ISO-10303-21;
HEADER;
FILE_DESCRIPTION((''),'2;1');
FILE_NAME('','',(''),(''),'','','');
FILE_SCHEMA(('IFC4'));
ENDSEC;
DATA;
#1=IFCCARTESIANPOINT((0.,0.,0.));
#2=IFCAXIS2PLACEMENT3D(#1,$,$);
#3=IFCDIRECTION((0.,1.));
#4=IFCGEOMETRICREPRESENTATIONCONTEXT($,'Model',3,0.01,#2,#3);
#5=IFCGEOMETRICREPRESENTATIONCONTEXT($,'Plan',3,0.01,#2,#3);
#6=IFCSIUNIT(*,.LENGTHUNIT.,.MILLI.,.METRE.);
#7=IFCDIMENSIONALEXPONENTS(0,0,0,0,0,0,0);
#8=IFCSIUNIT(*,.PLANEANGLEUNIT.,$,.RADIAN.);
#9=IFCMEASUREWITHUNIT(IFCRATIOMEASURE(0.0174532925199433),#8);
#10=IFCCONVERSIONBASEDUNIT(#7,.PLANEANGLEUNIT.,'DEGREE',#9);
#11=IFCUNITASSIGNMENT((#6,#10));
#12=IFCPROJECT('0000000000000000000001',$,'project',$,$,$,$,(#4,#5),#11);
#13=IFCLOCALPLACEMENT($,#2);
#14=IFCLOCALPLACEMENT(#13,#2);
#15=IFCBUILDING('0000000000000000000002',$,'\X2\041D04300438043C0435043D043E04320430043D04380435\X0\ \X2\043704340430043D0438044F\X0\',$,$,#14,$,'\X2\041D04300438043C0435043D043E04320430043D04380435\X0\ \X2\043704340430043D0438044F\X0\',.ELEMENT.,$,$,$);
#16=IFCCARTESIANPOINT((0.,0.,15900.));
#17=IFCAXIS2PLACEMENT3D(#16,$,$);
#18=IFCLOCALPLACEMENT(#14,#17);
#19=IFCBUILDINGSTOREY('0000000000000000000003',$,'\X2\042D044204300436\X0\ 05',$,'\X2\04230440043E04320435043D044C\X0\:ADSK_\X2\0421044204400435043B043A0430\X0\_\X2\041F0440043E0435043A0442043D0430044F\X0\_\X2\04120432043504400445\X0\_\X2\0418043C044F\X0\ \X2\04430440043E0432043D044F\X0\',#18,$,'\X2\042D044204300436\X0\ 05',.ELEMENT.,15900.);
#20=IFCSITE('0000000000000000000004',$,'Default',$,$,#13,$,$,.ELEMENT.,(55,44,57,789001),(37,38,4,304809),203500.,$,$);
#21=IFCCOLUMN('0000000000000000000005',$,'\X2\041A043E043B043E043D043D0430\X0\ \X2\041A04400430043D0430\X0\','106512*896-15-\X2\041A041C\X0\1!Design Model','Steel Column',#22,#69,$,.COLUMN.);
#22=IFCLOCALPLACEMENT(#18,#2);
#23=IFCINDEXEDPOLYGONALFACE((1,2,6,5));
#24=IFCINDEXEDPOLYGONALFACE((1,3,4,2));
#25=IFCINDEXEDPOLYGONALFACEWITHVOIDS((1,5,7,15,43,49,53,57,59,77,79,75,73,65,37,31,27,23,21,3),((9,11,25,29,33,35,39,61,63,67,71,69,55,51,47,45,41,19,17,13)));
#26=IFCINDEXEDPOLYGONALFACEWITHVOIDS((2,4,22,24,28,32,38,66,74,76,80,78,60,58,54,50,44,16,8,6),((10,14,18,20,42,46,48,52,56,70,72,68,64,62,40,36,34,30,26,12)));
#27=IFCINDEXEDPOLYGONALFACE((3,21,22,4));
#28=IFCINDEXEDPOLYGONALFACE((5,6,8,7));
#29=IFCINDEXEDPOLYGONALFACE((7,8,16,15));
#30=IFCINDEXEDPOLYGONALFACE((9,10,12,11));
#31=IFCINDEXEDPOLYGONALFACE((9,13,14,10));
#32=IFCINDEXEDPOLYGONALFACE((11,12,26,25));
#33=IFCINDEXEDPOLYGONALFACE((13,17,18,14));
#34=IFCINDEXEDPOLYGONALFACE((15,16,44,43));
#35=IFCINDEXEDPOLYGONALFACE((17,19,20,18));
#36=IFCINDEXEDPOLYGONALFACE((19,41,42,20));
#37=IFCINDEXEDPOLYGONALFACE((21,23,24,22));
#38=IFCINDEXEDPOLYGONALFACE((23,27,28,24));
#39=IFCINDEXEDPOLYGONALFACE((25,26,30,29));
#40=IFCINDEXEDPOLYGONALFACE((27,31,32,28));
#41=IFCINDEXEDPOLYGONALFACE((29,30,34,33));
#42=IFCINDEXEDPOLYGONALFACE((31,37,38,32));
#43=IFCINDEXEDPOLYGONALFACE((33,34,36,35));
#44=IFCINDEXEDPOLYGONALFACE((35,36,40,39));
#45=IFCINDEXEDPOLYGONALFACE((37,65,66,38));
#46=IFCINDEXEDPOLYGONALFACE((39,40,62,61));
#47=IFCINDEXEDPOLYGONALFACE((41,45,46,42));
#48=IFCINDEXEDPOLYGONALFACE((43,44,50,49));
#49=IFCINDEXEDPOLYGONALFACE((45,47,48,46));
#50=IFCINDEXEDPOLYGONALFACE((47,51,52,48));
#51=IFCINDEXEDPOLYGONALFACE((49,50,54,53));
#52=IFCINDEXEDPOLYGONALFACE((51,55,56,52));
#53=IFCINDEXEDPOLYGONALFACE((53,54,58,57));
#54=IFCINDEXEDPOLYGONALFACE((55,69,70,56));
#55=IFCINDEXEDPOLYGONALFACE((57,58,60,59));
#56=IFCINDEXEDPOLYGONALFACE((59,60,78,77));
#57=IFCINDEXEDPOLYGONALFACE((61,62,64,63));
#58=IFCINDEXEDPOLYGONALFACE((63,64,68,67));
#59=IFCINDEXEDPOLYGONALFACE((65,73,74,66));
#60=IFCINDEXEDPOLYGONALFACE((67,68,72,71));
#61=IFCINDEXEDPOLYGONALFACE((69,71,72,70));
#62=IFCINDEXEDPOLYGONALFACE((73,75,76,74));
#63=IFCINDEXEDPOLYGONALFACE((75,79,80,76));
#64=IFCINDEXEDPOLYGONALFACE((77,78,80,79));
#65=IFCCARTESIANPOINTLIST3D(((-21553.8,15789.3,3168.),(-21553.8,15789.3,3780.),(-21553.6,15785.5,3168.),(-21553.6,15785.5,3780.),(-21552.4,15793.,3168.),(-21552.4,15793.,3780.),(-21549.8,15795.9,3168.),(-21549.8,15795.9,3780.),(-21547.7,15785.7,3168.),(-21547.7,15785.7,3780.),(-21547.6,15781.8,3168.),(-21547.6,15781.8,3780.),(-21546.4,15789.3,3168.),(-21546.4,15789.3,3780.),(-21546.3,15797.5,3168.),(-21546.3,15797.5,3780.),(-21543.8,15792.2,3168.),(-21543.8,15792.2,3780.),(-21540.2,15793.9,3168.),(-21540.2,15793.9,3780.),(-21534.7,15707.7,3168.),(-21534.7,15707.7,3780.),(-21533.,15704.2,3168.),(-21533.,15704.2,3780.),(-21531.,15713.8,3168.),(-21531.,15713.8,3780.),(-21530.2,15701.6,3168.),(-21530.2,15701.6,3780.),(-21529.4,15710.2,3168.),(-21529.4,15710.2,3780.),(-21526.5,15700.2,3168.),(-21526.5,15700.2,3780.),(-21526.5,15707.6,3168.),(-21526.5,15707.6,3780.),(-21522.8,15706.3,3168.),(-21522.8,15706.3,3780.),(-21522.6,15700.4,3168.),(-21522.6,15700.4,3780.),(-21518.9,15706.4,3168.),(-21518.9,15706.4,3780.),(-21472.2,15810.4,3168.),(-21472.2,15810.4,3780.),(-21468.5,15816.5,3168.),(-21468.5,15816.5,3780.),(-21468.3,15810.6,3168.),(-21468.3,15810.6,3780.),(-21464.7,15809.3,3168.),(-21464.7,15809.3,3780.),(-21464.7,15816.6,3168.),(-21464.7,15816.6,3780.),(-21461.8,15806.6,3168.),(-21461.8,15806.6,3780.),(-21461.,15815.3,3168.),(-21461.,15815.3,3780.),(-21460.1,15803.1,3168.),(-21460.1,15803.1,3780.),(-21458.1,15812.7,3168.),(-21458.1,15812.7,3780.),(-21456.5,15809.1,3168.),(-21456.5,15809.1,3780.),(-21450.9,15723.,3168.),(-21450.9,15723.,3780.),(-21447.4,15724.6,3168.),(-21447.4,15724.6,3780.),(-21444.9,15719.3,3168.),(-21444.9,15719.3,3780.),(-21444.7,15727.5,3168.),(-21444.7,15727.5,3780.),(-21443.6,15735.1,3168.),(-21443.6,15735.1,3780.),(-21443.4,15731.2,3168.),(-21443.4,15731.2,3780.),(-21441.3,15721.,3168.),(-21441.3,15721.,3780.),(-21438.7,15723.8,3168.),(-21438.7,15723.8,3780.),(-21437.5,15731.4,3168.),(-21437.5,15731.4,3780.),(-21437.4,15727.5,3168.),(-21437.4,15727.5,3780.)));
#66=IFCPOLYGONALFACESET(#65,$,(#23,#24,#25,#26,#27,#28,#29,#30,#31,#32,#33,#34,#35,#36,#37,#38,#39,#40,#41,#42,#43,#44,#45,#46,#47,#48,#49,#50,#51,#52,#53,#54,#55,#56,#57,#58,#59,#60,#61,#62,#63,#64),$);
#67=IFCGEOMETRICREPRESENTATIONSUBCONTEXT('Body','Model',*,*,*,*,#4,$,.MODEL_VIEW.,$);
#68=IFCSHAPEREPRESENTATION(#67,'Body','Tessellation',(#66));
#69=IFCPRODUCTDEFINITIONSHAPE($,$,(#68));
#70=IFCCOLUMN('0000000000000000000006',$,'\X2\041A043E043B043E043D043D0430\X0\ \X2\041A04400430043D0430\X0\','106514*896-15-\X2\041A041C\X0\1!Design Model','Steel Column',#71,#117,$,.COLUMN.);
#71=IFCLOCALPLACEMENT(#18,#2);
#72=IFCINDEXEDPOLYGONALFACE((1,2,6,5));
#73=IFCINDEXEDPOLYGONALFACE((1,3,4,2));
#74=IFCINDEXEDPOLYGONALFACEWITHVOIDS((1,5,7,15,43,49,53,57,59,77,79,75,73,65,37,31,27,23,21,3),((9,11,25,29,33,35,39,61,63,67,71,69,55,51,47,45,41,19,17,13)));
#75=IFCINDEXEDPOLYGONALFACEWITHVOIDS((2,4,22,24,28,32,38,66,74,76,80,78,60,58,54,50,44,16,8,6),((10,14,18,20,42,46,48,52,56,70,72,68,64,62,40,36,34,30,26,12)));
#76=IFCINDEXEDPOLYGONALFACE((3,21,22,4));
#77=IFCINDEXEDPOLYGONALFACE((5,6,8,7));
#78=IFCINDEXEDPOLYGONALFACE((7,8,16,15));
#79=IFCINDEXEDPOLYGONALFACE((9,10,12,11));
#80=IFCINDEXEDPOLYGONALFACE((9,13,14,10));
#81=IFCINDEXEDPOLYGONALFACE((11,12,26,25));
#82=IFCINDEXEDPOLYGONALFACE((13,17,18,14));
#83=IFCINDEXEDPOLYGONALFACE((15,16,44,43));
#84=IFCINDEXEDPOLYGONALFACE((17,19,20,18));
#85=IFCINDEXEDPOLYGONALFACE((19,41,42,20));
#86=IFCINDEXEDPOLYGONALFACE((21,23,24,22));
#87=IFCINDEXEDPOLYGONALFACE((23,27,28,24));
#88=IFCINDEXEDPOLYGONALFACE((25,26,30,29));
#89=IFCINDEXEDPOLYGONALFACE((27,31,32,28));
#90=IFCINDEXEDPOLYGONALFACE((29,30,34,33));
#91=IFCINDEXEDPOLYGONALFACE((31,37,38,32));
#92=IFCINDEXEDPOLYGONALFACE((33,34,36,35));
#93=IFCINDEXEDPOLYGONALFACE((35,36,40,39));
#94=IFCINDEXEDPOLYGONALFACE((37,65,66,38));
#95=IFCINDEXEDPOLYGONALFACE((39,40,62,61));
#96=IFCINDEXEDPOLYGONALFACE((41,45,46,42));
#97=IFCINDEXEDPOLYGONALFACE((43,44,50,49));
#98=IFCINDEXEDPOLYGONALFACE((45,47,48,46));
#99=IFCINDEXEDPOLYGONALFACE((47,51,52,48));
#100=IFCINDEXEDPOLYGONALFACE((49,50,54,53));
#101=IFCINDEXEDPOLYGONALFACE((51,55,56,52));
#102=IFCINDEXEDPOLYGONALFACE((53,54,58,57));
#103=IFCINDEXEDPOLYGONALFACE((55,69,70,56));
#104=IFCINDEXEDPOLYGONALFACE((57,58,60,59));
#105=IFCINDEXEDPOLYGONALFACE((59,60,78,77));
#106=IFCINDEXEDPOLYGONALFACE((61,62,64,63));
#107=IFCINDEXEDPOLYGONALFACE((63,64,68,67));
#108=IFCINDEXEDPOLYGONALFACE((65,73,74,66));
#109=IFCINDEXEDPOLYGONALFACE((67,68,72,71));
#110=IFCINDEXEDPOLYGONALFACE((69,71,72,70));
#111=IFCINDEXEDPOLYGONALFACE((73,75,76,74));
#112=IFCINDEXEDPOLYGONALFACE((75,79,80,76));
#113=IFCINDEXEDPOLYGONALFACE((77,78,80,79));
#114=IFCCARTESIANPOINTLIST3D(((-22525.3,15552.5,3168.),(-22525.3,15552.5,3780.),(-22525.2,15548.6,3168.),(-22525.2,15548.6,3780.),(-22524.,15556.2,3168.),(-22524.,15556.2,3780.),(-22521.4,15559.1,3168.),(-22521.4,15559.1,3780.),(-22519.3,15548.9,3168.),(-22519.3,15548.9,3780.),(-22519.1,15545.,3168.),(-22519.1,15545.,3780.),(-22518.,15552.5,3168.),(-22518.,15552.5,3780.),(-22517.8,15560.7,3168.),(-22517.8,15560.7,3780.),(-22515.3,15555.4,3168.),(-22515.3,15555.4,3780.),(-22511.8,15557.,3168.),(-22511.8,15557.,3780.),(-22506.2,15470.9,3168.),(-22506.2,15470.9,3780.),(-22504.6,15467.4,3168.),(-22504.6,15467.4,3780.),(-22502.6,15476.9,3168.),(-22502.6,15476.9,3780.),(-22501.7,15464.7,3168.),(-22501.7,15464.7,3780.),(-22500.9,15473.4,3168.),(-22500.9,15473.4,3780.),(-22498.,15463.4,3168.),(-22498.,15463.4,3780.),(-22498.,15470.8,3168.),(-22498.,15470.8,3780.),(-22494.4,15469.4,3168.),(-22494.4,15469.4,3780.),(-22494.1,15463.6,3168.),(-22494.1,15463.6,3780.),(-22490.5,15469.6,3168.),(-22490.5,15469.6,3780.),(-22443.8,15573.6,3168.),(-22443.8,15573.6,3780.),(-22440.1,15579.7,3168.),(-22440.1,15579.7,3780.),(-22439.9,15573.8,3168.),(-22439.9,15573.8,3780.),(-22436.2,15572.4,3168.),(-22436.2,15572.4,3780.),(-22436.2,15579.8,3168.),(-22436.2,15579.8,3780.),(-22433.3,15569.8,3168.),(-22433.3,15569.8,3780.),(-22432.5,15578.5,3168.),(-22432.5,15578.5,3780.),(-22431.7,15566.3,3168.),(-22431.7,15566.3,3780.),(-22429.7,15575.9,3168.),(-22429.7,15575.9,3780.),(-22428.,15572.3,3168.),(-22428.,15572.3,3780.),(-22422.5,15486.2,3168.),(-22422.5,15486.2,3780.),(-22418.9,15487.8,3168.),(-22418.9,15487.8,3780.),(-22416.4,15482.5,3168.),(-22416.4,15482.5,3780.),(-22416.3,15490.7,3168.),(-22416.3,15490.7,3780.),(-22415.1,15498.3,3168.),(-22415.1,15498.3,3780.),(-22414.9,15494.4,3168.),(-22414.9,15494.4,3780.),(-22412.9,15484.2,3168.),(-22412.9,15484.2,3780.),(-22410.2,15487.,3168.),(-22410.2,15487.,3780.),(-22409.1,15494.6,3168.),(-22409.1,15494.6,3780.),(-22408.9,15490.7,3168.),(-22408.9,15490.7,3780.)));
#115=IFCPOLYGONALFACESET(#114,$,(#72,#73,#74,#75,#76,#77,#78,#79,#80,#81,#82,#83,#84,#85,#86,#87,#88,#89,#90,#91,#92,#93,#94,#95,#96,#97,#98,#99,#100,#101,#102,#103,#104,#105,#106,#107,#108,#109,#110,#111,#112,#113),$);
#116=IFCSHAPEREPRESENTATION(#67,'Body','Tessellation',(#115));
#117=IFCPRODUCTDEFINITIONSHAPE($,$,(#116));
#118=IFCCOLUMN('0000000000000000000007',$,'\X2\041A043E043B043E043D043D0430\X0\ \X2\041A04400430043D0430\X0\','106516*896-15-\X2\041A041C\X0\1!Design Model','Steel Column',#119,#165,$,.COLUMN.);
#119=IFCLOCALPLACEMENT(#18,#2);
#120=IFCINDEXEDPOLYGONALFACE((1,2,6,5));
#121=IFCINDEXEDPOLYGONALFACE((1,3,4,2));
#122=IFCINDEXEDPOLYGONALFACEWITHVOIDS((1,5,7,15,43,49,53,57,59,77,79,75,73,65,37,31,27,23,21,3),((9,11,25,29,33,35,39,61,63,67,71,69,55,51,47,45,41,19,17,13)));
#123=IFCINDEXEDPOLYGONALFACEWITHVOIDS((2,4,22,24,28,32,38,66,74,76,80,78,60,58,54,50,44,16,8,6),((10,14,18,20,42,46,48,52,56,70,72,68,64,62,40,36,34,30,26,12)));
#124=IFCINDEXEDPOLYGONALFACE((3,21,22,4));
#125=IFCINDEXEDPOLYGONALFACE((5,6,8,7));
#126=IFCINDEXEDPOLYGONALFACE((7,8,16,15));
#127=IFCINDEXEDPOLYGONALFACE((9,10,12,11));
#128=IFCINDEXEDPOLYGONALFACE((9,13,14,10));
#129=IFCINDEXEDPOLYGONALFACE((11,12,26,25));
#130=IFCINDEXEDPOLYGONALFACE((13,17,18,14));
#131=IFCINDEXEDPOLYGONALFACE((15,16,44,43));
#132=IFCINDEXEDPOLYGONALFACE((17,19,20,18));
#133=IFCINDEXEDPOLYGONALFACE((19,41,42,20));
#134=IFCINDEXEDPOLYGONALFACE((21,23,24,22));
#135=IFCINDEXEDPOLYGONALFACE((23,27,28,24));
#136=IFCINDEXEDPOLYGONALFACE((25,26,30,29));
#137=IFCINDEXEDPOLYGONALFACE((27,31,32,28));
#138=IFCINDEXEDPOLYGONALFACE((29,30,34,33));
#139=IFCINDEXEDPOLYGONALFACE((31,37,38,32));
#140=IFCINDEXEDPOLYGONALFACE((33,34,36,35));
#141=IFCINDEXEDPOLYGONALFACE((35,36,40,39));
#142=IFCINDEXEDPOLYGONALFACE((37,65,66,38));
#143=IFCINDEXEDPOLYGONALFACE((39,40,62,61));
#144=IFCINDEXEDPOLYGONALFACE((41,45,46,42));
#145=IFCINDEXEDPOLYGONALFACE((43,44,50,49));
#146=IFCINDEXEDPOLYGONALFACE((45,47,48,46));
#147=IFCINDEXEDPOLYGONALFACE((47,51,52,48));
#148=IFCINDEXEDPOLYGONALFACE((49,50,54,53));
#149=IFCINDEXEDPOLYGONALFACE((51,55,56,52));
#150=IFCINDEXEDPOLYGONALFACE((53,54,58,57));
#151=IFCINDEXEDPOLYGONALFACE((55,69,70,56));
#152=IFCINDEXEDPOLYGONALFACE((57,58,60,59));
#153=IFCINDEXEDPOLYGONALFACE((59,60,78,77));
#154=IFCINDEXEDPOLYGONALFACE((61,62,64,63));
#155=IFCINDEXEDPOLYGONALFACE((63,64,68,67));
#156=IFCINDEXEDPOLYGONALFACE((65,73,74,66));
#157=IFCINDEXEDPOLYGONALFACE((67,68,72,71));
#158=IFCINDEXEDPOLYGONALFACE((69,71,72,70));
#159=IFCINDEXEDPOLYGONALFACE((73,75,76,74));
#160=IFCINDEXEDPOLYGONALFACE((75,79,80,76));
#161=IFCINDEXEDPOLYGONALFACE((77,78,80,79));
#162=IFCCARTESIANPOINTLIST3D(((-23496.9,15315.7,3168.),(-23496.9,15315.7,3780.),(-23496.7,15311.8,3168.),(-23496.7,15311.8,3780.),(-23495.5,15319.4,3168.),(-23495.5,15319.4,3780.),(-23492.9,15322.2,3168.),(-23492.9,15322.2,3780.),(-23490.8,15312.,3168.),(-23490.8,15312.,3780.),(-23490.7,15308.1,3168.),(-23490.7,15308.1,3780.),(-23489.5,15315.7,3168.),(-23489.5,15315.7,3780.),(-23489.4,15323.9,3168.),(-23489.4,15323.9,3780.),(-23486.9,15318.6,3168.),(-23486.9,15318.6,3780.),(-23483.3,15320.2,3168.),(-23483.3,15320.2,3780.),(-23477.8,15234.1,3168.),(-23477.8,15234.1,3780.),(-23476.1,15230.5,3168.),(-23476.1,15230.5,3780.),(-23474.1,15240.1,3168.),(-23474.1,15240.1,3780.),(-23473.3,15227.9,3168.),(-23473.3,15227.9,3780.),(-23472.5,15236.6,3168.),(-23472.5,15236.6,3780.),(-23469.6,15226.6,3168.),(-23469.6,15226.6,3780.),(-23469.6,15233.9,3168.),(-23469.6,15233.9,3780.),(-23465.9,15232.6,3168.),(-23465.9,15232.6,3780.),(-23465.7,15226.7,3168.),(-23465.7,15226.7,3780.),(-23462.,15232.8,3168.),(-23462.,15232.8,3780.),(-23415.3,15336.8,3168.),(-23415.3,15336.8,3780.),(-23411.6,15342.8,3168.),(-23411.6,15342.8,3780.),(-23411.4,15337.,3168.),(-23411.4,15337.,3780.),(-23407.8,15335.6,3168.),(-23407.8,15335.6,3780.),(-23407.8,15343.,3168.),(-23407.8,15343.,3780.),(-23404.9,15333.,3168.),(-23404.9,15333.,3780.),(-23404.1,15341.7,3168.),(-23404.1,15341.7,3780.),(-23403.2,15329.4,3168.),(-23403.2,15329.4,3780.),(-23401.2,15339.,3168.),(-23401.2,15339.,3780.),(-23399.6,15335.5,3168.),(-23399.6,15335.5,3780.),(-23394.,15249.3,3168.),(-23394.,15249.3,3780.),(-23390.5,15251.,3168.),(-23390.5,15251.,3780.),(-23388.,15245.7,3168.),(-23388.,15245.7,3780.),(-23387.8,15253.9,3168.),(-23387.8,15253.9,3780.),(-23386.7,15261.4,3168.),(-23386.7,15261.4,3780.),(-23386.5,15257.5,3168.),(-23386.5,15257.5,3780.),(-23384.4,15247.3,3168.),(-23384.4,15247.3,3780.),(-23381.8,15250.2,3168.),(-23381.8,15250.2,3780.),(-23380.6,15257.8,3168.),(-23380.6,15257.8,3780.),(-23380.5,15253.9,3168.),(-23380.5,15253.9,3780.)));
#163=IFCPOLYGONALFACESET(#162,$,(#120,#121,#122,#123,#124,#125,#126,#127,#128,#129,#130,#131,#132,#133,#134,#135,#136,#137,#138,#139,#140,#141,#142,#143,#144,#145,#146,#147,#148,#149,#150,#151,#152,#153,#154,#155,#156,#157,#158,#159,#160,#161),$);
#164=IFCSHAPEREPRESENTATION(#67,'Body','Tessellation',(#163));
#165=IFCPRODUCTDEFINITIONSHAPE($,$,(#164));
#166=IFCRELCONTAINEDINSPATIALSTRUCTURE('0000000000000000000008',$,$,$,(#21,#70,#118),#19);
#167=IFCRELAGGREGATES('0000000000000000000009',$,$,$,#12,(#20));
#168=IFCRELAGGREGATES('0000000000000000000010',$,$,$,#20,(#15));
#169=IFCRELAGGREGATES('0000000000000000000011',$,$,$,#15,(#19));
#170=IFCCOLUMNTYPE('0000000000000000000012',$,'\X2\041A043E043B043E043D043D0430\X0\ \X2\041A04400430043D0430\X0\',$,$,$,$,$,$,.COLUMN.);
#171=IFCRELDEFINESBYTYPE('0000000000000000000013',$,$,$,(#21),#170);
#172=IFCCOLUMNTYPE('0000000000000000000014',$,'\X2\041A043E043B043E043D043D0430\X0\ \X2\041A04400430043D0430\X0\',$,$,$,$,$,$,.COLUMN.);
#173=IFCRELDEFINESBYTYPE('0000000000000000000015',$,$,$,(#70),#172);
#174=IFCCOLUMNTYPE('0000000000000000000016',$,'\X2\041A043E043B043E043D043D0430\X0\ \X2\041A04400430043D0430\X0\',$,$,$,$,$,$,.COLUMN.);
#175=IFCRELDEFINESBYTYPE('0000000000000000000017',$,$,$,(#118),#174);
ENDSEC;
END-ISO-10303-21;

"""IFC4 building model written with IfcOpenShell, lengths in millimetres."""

from ifc_helpers import new_model, entity, si_unit, converted_unit, direction, frame, origin, place, context, subcontext, project, spatial, indexed_curve, outline, extrude, type_object, element, save


model = new_model("IFC4")

# Units and contexts
model_context = context("Model", 3, precision=0.01, world=origin(), true_north=direction((0.0, 1.0)))
plan_context = context("Plan", 3, precision=0.01, world=origin(), true_north=direction((0.0, 1.0)))
body_context = subcontext(model_context, "Body", "Model", "MODEL_VIEW")
ifc_project = project(units=[si_unit("LENGTHUNIT", "METRE", prefix="MILLI"), converted_unit("PLANEANGLEUNIT", "DEGREE", entity("IfcRatioMeasure", 0.0174532925199433), si_unit("PLANEANGLEUNIT", "RADIAN"), dimensions=[0, 0, 0, 0, 0, 0, 0])], contexts=[model_context, plan_context])

# Site, building, storey
site_placement = place(None, origin())
site = spatial("IfcSite", under=ifc_project, at=site_placement, Name="Default", CompositionType="ELEMENT", RefLatitude=(55, 44, 57, 789001), RefLongitude=(37, 38, 4, 304809), RefElevation=203500.0)
building_placement = place(site_placement, origin())
building = spatial("IfcBuilding", under=site, at=building_placement, Name="Наименование здания", LongName="Наименование здания", CompositionType="ELEMENT")
storey_placement = place(building_placement, frame((0.0, 0.0, 15900.0)))
storey = spatial("IfcBuildingStorey", under=building, at=storey_placement, Name="Этаж 05", ObjectType="Уровень:ADSK_Стрелка_Проектная_Вверх_Имя уровня", LongName="Этаж 05", CompositionType="ELEMENT", Elevation=15900.0)

# Columns
column_type_1 = type_object("IfcColumnType", Name="Колонна Крана", PredefinedType="COLUMN")
placement = place(storey_placement, origin())
element("IfcColumn", 1, at=placement, inside=storey, type_object=column_type_1, Name="Колонна Крана", Description="106512*896-15-КМ1!Design Model", ObjectType="Steel Column", PredefinedType="COLUMN", context=body_context, shape_type="SweptSolid", body=[
    extrude(outline(indexed_curve([(29.5, -56.8), (33.4, -56.8), (37.0, -55.3), (39.7, -52.6), (41.2, -49.0), (56.8, 29.5), (56.8, 33.4), (55.3, 37.0), (52.6, 39.7), (49.0, 41.2), (-29.5, 56.8), (-33.4, 56.8), (-37.0, 55.3), (-39.7, 52.6), (-41.2, 49.0), (-56.8, -29.5), (-56.8, -33.4), (-55.3, -37.0), (-52.6, -39.7), (-49.0, -41.2), (29.5, -56.8)], self_intersect=False), holes=[indexed_curve([(-43.1, -37.3), (-46.7, -35.8), (-49.5, -33.1), (-51.0, -29.5), (-51.0, -25.5), (-37.3, 43.1), (-35.8, 46.7), (-33.1, 49.5), (-29.5, 51.0), (-25.5, 51.0), (43.1, 37.3), (46.7, 35.8), (49.5, 33.1), (51.0, 29.5), (51.0, 25.5), (37.3, -43.1), (35.8, -46.7), (33.1, -49.5), (29.5, -51.0), (25.5, -51.0), (-43.1, -37.3)], self_intersect=False)]), frame((-21495.6, 15758.4, 3168.0), z_axis=(0.0, 0.0, 1.0), x_axis=(0.906681, 0.421816, 0.0)), (0.0, 0.0, 1.0), 612.0),
])
column_type_2 = type_object("IfcColumnType", Name="Колонна Крана", PredefinedType="COLUMN")
element("IfcColumn", 2, at=placement, inside=storey, type_object=column_type_2, Name="Колонна Крана", Description="106514*896-15-КМ1!Design Model", ObjectType="Steel Column", PredefinedType="COLUMN", context=body_context, shape_type="SweptSolid", body=[
    extrude(outline(indexed_curve([(29.5, -56.8), (33.4, -56.8), (37.0, -55.3), (39.7, -52.6), (41.2, -49.0), (56.8, 29.5), (56.8, 33.4), (55.3, 37.0), (52.6, 39.7), (49.0, 41.2), (-29.5, 56.8), (-33.4, 56.8), (-37.0, 55.3), (-39.7, 52.6), (-41.2, 49.0), (-56.8, -29.5), (-56.8, -33.4), (-55.3, -37.0), (-52.6, -39.7), (-49.0, -41.2), (29.5, -56.8)], self_intersect=False), holes=[indexed_curve([(-43.1, -37.3), (-46.7, -35.8), (-49.5, -33.1), (-51.0, -29.5), (-51.0, -25.5), (-37.3, 43.1), (-35.8, 46.7), (-33.1, 49.5), (-29.5, 51.0), (-25.5, 51.0), (43.1, 37.3), (46.7, 35.8), (49.5, 33.1), (51.0, 29.5), (51.0, 25.5), (37.3, -43.1), (35.8, -46.7), (33.1, -49.5), (29.5, -51.0), (25.5, -51.0), (-43.1, -37.3)], self_intersect=False)]), frame((-22467.1, 15521.6, 3168.0), z_axis=(0.0, 0.0, 1.0), x_axis=(0.906681, 0.421816, 0.0)), (0.0, 0.0, 1.0), 612.0),
])
column_type_3 = type_object("IfcColumnType", Name="Колонна Крана", PredefinedType="COLUMN")
element("IfcColumn", 3, at=placement, inside=storey, type_object=column_type_3, Name="Колонна Крана", Description="106516*896-15-КМ1!Design Model", ObjectType="Steel Column", PredefinedType="COLUMN", context=body_context, shape_type="SweptSolid", body=[
    extrude(outline(indexed_curve([(29.5, -56.8), (33.4, -56.8), (37.0, -55.3), (39.7, -52.6), (41.2, -49.0), (56.8, 29.5), (56.8, 33.4), (55.3, 37.0), (52.6, 39.7), (49.0, 41.2), (-29.5, 56.8), (-33.4, 56.8), (-37.0, 55.3), (-39.7, 52.6), (-41.2, 49.0), (-56.8, -29.5), (-56.8, -33.4), (-55.3, -37.0), (-52.6, -39.7), (-49.0, -41.2), (29.5, -56.8)], self_intersect=False), holes=[indexed_curve([(-43.1, -37.3), (-46.7, -35.8), (-49.5, -33.1), (-51.0, -29.5), (-51.0, -25.5), (-37.3, 43.1), (-35.8, 46.7), (-33.1, 49.5), (-29.5, 51.0), (-25.5, 51.0), (43.1, 37.3), (46.7, 35.8), (49.5, 33.1), (51.0, 29.5), (51.0, 25.5), (37.3, -43.1), (35.8, -46.7), (33.1, -49.5), (29.5, -51.0), (25.5, -51.0), (-43.1, -37.3)], self_intersect=False)]), frame((-23438.7, 15284.8, 3168.0), z_axis=(0.0, 0.0, 1.0), x_axis=(0.906681, 0.421816, 0.0)), (0.0, 0.0, 1.0), 612.0),
])

save(model, "model.ifc")
